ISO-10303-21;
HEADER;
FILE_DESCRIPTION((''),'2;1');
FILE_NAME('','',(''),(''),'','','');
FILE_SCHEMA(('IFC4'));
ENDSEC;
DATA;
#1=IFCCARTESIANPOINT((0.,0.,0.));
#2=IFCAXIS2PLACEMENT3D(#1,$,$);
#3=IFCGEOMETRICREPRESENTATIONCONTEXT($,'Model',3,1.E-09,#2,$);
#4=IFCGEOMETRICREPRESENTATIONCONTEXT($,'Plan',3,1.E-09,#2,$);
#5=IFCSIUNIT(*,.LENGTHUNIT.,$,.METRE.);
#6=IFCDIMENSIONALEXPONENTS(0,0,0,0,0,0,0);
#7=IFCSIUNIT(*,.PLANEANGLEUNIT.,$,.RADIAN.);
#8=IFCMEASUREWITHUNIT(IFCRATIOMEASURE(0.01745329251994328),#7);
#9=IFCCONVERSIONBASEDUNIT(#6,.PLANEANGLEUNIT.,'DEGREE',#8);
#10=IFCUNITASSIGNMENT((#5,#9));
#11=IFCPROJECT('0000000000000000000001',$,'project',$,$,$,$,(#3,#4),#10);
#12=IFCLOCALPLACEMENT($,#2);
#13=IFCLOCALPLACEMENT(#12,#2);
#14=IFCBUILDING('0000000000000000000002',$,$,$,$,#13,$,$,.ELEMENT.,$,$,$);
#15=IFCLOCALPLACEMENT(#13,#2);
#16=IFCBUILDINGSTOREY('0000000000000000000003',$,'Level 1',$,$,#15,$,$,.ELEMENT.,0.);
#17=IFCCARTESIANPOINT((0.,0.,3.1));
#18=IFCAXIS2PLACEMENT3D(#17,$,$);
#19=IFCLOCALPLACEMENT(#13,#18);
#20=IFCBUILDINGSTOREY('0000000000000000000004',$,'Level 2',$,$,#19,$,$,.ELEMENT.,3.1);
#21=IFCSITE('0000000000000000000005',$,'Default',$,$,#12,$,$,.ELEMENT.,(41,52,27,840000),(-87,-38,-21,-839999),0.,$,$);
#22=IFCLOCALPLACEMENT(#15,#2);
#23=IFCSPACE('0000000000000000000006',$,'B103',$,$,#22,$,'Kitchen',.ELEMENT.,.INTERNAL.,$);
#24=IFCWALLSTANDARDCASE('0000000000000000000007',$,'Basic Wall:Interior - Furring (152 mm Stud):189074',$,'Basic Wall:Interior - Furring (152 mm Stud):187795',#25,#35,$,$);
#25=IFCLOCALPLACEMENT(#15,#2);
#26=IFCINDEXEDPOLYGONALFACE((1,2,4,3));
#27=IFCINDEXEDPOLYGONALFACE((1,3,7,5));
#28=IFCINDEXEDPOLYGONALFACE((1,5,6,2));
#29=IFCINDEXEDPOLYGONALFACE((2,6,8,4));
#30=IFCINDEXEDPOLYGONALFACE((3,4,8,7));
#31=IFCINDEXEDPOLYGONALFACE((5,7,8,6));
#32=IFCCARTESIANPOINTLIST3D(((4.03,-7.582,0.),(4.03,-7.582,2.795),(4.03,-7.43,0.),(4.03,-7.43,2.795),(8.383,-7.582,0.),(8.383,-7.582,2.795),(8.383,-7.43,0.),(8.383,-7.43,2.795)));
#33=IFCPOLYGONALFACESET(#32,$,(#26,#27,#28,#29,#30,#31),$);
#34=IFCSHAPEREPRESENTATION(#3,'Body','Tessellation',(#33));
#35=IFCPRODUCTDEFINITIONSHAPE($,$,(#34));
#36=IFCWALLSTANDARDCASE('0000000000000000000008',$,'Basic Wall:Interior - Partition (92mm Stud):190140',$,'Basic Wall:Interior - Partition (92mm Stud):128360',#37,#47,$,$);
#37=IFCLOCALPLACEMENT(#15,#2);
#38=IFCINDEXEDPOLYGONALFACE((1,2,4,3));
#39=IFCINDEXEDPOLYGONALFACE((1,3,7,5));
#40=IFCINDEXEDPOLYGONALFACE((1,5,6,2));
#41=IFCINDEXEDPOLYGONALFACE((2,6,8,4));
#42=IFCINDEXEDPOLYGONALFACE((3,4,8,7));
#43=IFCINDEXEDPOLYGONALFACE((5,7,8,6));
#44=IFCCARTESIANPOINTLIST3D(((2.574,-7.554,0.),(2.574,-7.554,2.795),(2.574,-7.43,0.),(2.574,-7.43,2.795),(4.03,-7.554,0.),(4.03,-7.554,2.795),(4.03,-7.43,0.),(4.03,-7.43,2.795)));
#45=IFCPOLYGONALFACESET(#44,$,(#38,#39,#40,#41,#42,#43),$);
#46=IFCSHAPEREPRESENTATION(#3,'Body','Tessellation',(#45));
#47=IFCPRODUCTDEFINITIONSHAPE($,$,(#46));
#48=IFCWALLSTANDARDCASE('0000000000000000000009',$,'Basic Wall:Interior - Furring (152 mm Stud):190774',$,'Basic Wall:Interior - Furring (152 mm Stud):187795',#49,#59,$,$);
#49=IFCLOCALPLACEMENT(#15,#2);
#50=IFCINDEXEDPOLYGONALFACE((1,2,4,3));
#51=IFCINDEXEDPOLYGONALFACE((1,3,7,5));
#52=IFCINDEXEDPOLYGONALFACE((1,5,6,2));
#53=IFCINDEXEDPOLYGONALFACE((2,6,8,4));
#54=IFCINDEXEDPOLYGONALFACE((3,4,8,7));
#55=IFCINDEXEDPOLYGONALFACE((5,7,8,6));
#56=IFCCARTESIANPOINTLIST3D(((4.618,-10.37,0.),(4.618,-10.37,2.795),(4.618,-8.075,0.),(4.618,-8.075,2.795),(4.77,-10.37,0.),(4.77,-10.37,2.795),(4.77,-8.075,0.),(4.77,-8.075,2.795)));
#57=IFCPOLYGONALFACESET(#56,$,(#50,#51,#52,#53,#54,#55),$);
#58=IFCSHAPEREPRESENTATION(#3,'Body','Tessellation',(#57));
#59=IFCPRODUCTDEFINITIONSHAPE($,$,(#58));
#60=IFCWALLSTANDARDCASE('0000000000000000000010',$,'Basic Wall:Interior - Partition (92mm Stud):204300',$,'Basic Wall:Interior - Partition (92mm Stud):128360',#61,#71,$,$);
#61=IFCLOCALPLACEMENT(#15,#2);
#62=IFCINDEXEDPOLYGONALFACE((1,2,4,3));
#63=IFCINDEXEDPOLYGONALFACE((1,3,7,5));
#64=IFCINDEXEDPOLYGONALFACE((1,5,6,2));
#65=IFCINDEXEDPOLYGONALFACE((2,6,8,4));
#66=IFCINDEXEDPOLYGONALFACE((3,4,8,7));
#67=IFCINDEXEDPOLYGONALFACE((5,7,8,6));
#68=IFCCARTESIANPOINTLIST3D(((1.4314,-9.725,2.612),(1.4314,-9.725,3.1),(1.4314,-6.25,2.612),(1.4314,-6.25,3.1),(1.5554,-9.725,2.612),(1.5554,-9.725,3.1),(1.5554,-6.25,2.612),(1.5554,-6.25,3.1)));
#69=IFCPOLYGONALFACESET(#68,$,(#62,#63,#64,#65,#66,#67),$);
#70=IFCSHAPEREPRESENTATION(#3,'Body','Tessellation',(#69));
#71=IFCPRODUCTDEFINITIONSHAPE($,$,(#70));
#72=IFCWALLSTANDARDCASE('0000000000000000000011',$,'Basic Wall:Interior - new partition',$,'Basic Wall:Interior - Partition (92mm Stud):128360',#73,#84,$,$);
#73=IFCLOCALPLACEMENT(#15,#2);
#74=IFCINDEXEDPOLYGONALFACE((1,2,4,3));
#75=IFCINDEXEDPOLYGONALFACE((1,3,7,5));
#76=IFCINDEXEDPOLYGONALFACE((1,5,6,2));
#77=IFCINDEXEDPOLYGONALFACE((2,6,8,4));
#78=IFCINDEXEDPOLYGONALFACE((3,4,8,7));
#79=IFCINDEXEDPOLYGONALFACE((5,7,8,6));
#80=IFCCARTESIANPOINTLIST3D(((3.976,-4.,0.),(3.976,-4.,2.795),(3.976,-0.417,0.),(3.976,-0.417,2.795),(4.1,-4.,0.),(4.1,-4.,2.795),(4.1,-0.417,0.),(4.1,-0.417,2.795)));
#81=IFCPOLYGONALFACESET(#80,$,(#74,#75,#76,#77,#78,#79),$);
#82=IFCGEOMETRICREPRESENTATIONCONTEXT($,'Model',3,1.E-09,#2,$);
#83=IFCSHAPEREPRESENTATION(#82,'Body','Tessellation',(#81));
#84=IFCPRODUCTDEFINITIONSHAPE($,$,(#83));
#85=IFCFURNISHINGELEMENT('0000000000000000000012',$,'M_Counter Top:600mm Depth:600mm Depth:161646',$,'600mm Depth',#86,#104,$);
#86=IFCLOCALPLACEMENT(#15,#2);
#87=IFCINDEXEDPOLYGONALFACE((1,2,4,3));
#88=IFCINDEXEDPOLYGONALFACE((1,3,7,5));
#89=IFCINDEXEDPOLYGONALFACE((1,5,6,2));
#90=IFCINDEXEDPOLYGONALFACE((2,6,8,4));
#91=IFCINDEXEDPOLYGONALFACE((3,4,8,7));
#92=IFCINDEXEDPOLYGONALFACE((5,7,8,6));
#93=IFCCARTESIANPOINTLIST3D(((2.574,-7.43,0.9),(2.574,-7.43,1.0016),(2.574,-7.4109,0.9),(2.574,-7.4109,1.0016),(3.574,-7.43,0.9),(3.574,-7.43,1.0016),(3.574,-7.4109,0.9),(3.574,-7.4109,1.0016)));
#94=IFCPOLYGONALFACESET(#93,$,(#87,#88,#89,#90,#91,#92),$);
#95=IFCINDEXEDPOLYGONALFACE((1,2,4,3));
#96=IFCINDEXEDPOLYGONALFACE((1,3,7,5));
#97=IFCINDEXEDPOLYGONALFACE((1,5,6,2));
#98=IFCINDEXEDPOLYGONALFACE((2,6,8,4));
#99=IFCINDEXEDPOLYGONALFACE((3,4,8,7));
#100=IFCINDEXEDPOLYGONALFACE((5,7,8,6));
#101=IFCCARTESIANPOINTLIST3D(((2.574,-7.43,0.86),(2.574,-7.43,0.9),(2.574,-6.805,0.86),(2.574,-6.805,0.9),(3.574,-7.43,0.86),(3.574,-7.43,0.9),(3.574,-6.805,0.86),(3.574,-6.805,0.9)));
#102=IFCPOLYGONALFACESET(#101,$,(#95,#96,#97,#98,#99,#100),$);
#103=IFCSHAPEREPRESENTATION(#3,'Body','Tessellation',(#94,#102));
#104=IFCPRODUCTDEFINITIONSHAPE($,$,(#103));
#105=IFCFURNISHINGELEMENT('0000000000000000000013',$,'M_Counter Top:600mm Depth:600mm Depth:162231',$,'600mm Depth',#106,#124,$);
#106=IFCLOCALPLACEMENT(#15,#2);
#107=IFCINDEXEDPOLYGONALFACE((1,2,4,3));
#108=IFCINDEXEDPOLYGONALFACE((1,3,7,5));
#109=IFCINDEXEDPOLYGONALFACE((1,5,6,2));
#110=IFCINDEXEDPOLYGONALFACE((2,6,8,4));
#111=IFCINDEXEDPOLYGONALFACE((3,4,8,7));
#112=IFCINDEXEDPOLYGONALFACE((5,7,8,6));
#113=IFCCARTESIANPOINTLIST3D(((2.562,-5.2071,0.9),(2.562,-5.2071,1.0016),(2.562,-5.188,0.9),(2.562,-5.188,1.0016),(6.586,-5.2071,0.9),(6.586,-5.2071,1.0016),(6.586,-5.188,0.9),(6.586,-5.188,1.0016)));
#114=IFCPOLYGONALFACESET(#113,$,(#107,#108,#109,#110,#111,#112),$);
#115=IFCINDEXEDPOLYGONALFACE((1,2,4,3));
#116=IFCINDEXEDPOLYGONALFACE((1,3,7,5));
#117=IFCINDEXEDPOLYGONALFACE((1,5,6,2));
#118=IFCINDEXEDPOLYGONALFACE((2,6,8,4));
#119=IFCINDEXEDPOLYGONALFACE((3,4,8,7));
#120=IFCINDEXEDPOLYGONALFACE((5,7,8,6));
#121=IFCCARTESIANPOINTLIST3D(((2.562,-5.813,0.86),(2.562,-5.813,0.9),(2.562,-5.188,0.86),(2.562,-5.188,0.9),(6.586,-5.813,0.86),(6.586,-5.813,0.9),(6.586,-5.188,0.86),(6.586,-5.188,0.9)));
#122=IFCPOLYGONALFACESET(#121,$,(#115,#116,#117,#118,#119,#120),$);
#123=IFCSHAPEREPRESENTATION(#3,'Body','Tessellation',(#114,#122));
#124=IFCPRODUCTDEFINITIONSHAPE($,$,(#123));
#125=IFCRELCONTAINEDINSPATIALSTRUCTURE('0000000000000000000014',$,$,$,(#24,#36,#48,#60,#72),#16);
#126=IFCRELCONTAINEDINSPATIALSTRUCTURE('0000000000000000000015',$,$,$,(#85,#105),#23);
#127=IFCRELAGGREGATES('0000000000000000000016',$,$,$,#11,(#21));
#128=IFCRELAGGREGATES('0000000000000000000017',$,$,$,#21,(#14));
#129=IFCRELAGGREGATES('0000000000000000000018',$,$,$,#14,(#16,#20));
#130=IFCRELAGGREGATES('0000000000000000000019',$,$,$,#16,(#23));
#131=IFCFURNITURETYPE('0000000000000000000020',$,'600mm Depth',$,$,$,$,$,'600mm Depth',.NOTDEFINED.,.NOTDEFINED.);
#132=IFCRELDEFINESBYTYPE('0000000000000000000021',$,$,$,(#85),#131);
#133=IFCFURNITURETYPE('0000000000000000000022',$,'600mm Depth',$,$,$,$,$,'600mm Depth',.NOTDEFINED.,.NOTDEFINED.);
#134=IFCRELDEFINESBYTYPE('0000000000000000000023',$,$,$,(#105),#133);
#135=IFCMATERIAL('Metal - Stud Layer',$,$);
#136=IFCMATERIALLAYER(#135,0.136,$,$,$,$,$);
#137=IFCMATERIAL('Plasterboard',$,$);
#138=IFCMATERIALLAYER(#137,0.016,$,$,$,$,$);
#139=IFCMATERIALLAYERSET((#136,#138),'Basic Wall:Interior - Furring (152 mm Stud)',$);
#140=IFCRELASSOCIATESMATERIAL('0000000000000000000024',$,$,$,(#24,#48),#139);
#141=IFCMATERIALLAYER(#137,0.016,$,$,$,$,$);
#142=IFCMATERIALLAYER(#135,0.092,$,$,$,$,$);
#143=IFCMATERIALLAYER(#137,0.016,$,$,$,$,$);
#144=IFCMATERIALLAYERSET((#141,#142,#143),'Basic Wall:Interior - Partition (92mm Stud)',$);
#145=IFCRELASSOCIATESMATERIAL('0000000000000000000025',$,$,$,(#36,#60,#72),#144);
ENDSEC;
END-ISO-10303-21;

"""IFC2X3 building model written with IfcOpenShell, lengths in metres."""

from ifc_helpers import new_model, entity, si_unit, converted_unit, frame, frame_2d, origin, origin_2d_with_axis, place, context, project, spatial, polyline, rectangle, extrude, clip, bounded_halfspace, source, transform, mapped, material, layer, layer_set, layer_usage, type_object, type_shapes, element, save


model = new_model("IFC2X3")

# Units and contexts
model_context_1 = context("Model", 3, precision=1e-09, world=origin())
plan_context = context("Plan", 3, precision=1e-09, world=origin())
model_context_2 = context("Model", 3, precision=1e-09, world=origin())
ifc_project = project(units=[si_unit("LENGTHUNIT", "METRE"), converted_unit("PLANEANGLEUNIT", "DEGREE", entity("IfcRatioMeasure", 0.01745329251994328), si_unit("PLANEANGLEUNIT", "RADIAN"), dimensions=[0, 0, 0, 0, 0, 0, 0])], contexts=[model_context_1, plan_context])

# Site, building, storey
site_placement = place(None, origin())
site = spatial("IfcSite", under=ifc_project, at=site_placement, Name="Default", CompositionType="ELEMENT", RefLatitude=(41, 52, 27, 840000), RefLongitude=(-87, -38, -21, -839999), RefElevation=0.0)
building_placement = place(site_placement, origin())
building = spatial("IfcBuilding", under=site, at=building_placement, CompositionType="ELEMENT")
storey_1_placement = place(building_placement, origin())
storey_1 = spatial("IfcBuildingStorey", under=building, at=storey_1_placement, Name="Level 1", CompositionType="ELEMENT", Elevation=0.0)

# Shared definitions
ifc_material_1 = material(Name="Metal - Stud Layer")
ifc_material_2 = material(Name="Plasterboard")

# Shared definitions
ifc_layer_1 = layer(ifc_material_2, 0.016)
ifc_layer_2 = layer(ifc_material_1, 0.092)
ifc_layer_3 = layer(ifc_material_2, 0.016)
ifc_layer_set_1 = layer_set([ifc_layer_1, ifc_layer_2, ifc_layer_3], Name="Basic Wall:Interior - Partition (92mm Stud)")

# Shared definitions
storey_2_placement = place(building_placement, frame((0.0, 0.0, 3.1)))
storey_2 = spatial("IfcBuildingStorey", under=building, at=storey_2_placement, Name="Level 2", CompositionType="ELEMENT", Elevation=3.1)

# Walls
ifc_layer_4 = layer(ifc_material_1, 0.136)
ifc_layer_5 = layer(ifc_material_2, 0.016)
ifc_layer_set_2 = layer_set([ifc_layer_4, ifc_layer_5], Name="Basic Wall:Interior - Furring (152 mm Stud)")
ifc_layer_usage_1 = layer_usage(ifc_layer_set_2, "AXIS2", "NEGATIVE", 0.076)
wall_1_placement = place(storey_1_placement, frame((8.383, -7.506, 0.0), z_axis=(0.0, 0.0, 1.0), x_axis=(-1.0, 0.0, 0.0)))
element("IfcWallStandardCase", 1, at=wall_1_placement, inside=storey_1, material=ifc_layer_usage_1, Name="Basic Wall:Interior - Furring (152 mm Stud):189074", ObjectType="Basic Wall:Interior - Furring (152 mm Stud):187795", context=model_context_1, shape_type="Clipping", body=[
    clip(extrude(rectangle(XDim=4.353, YDim=0.152, at=frame_2d((2.1765, 0.0), x_axis=(-1.0, 0.0))), origin(), (0.0, 0.0, 1.0), 2.795), bounded_halfspace(frame((0.0, -0.076, 2.795), z_axis=(0.0, 0.0, -1.0), x_axis=(0.0, 1.0, 0.0)), True, frame((0.0, -0.076, 2.795)), polyline([(0.0, 0.0), (3.708, 0.0), (3.708, 0.152), (0.0, 0.152), (0.0, 0.0)]))),
])
ifc_layer_usage_2 = layer_usage(ifc_layer_set_1, "AXIS2", "NEGATIVE", 0.062)
wall_2_placement = place(storey_1_placement, frame((4.03, -7.492, 0.0), z_axis=(0.0, 0.0, 1.0), x_axis=(-1.0, 0.0, 0.0)))
element("IfcWallStandardCase", 2, at=wall_2_placement, inside=storey_1, material=ifc_layer_usage_2, Name="Basic Wall:Interior - Partition (92mm Stud):190140", ObjectType="Basic Wall:Interior - Partition (92mm Stud):128360", context=model_context_1, shape_type="SweptSolid", body=[
    extrude(rectangle(XDim=1.456, YDim=0.124, at=frame_2d((0.728, 0.0), x_axis=(-1.0, 0.0))), origin(), (0.0, 0.0, 1.0), 2.795),
])
ifc_layer_usage_3 = layer_usage(ifc_layer_set_2, "AXIS2", "POSITIVE", -0.076)
wall_3_placement = place(storey_1_placement, frame((4.694, -8.075, 0.0), z_axis=(0.0, 0.0, 1.0), x_axis=(0.0, -1.0, 0.0)))
element("IfcWallStandardCase", 3, at=wall_3_placement, inside=storey_1, material=ifc_layer_usage_3, Name="Basic Wall:Interior - Furring (152 mm Stud):190774", ObjectType="Basic Wall:Interior - Furring (152 mm Stud):187795", context=model_context_1, shape_type="SweptSolid", body=[
    extrude(rectangle(XDim=2.295, YDim=0.152, at=frame_2d((1.1475, 0.0), x_axis=(-1.0, 0.0))), origin(), (0.0, 0.0, 1.0), 2.795),
])
ifc_layer_usage_4 = layer_usage(ifc_layer_set_1, "AXIS2", "NEGATIVE", 0.062)
wall_4_placement = place(storey_1_placement, frame((1.4934, -6.25, 2.612), z_axis=(0.0, 0.0, 1.0), x_axis=(0.0, -1.0, 0.0)))
element("IfcWallStandardCase", 4, at=wall_4_placement, inside=storey_1, material=ifc_layer_usage_4, Name="Basic Wall:Interior - Partition (92mm Stud):204300", ObjectType="Basic Wall:Interior - Partition (92mm Stud):128360", context=model_context_1, shape_type="SweptSolid", body=[
    extrude(rectangle(XDim=3.475, YDim=0.124, at=frame_2d((1.7375, 0.0), x_axis=(-1.0, 0.0))), origin(), (0.0, 0.0, 1.0), 0.488),
])
ifc_layer_usage_5 = layer_usage(ifc_layer_set_1, "AXIS2", "NEGATIVE", 0.062)
wall_5_placement = place(storey_1_placement, frame((4.038, -0.417, 0.0), z_axis=(0.0, 0.0, 1.0), x_axis=(0.0, -1.0, 0.0)))
element("IfcWallStandardCase", 5, at=wall_5_placement, inside=storey_1, material=ifc_layer_usage_5, Name="Basic Wall:Interior - new partition", ObjectType="Basic Wall:Interior - Partition (92mm Stud):128360", context=model_context_2, shape_type="SweptSolid", body=[
    extrude(rectangle(XDim=3.583, YDim=0.124, at=frame_2d((1.7915, 0.0), x_axis=(-1.0, 0.0))), origin(), (0.0, 0.0, 1.0), 2.795),
])

# Shared definitions
space_1_placement = place(storey_1_placement, origin())
space_1 = spatial("IfcSpace", under=storey_1, at=space_1_placement, Name="B103", LongName="Kitchen", CompositionType="ELEMENT", InteriorOrExteriorSpace="INTERNAL")

# Furnishing elements
furniture_type_1 = type_object("IfcFurnitureType", Name="600mm Depth", ElementType="600mm Depth", AssemblyPlace="NOTDEFINED")
shared_shape_1 = source(origin(), model_context_1, "Body", "SweptSolid", [
    extrude(rectangle(XDim=0.0191, YDim=1.0, at=origin_2d_with_axis()), frame((-0.7005, -0.0095, 0.9), z_axis=(0.0, 0.0, 1.0), x_axis=(0.0, -1.0, 0.0)), (0.0, 0.0, 1.0), 0.1016),
    extrude(rectangle(XDim=1.0, YDim=0.625, at=origin_2d_with_axis()), frame((-0.7005, -0.3125, 0.86), z_axis=(0.0, 0.0, 1.0), x_axis=(-1.0, 0.0, 0.0)), (0.0, 0.0, 1.0), 0.04),
])
type_shapes(furniture_type_1, [shared_shape_1])
furnishing_1_placement = place(space_1_placement, frame((2.3735, -7.43, 0.0), z_axis=(0.0, 0.0, 1.0), x_axis=(-1.0, 0.0, 0.0)))
element("IfcFurnishingElement", 6, at=furnishing_1_placement, inside=space_1, type_object=furniture_type_1, Name="M_Counter Top:600mm Depth:600mm Depth:161646", ObjectType="600mm Depth", context=model_context_1, shape_type="MappedRepresentation", body=[
    mapped(shared_shape_1, transform((0.0, 0.0, 0.0), scale=1.0)),
])
furniture_type_2 = type_object("IfcFurnitureType", Name="600mm Depth", ElementType="600mm Depth", AssemblyPlace="NOTDEFINED")
shared_shape_2 = source(origin(), model_context_1, "Body", "SweptSolid", [
    extrude(rectangle(XDim=0.0191, YDim=4.024, at=origin_2d_with_axis()), frame((0.8115, -0.0095, 0.9), z_axis=(0.0, 0.0, 1.0), x_axis=(0.0, -1.0, 0.0)), (0.0, 0.0, 1.0), 0.1016),
    extrude(rectangle(XDim=4.024, YDim=0.625, at=origin_2d_with_axis()), frame((0.8115, -0.3125, 0.86), z_axis=(0.0, 0.0, 1.0), x_axis=(-1.0, 0.0, 0.0)), (0.0, 0.0, 1.0), 0.04),
])
type_shapes(furniture_type_2, [shared_shape_2])
furnishing_2_placement = place(space_1_placement, frame((3.7625, -5.188, 0.0)))
element("IfcFurnishingElement", 7, at=furnishing_2_placement, inside=space_1, type_object=furniture_type_2, Name="M_Counter Top:600mm Depth:600mm Depth:162231", ObjectType="600mm Depth", context=model_context_1, shape_type="MappedRepresentation", body=[
    mapped(shared_shape_2, transform((0.0, 0.0, 0.0), scale=1.0)),
])

save(model, "model.ifc")
